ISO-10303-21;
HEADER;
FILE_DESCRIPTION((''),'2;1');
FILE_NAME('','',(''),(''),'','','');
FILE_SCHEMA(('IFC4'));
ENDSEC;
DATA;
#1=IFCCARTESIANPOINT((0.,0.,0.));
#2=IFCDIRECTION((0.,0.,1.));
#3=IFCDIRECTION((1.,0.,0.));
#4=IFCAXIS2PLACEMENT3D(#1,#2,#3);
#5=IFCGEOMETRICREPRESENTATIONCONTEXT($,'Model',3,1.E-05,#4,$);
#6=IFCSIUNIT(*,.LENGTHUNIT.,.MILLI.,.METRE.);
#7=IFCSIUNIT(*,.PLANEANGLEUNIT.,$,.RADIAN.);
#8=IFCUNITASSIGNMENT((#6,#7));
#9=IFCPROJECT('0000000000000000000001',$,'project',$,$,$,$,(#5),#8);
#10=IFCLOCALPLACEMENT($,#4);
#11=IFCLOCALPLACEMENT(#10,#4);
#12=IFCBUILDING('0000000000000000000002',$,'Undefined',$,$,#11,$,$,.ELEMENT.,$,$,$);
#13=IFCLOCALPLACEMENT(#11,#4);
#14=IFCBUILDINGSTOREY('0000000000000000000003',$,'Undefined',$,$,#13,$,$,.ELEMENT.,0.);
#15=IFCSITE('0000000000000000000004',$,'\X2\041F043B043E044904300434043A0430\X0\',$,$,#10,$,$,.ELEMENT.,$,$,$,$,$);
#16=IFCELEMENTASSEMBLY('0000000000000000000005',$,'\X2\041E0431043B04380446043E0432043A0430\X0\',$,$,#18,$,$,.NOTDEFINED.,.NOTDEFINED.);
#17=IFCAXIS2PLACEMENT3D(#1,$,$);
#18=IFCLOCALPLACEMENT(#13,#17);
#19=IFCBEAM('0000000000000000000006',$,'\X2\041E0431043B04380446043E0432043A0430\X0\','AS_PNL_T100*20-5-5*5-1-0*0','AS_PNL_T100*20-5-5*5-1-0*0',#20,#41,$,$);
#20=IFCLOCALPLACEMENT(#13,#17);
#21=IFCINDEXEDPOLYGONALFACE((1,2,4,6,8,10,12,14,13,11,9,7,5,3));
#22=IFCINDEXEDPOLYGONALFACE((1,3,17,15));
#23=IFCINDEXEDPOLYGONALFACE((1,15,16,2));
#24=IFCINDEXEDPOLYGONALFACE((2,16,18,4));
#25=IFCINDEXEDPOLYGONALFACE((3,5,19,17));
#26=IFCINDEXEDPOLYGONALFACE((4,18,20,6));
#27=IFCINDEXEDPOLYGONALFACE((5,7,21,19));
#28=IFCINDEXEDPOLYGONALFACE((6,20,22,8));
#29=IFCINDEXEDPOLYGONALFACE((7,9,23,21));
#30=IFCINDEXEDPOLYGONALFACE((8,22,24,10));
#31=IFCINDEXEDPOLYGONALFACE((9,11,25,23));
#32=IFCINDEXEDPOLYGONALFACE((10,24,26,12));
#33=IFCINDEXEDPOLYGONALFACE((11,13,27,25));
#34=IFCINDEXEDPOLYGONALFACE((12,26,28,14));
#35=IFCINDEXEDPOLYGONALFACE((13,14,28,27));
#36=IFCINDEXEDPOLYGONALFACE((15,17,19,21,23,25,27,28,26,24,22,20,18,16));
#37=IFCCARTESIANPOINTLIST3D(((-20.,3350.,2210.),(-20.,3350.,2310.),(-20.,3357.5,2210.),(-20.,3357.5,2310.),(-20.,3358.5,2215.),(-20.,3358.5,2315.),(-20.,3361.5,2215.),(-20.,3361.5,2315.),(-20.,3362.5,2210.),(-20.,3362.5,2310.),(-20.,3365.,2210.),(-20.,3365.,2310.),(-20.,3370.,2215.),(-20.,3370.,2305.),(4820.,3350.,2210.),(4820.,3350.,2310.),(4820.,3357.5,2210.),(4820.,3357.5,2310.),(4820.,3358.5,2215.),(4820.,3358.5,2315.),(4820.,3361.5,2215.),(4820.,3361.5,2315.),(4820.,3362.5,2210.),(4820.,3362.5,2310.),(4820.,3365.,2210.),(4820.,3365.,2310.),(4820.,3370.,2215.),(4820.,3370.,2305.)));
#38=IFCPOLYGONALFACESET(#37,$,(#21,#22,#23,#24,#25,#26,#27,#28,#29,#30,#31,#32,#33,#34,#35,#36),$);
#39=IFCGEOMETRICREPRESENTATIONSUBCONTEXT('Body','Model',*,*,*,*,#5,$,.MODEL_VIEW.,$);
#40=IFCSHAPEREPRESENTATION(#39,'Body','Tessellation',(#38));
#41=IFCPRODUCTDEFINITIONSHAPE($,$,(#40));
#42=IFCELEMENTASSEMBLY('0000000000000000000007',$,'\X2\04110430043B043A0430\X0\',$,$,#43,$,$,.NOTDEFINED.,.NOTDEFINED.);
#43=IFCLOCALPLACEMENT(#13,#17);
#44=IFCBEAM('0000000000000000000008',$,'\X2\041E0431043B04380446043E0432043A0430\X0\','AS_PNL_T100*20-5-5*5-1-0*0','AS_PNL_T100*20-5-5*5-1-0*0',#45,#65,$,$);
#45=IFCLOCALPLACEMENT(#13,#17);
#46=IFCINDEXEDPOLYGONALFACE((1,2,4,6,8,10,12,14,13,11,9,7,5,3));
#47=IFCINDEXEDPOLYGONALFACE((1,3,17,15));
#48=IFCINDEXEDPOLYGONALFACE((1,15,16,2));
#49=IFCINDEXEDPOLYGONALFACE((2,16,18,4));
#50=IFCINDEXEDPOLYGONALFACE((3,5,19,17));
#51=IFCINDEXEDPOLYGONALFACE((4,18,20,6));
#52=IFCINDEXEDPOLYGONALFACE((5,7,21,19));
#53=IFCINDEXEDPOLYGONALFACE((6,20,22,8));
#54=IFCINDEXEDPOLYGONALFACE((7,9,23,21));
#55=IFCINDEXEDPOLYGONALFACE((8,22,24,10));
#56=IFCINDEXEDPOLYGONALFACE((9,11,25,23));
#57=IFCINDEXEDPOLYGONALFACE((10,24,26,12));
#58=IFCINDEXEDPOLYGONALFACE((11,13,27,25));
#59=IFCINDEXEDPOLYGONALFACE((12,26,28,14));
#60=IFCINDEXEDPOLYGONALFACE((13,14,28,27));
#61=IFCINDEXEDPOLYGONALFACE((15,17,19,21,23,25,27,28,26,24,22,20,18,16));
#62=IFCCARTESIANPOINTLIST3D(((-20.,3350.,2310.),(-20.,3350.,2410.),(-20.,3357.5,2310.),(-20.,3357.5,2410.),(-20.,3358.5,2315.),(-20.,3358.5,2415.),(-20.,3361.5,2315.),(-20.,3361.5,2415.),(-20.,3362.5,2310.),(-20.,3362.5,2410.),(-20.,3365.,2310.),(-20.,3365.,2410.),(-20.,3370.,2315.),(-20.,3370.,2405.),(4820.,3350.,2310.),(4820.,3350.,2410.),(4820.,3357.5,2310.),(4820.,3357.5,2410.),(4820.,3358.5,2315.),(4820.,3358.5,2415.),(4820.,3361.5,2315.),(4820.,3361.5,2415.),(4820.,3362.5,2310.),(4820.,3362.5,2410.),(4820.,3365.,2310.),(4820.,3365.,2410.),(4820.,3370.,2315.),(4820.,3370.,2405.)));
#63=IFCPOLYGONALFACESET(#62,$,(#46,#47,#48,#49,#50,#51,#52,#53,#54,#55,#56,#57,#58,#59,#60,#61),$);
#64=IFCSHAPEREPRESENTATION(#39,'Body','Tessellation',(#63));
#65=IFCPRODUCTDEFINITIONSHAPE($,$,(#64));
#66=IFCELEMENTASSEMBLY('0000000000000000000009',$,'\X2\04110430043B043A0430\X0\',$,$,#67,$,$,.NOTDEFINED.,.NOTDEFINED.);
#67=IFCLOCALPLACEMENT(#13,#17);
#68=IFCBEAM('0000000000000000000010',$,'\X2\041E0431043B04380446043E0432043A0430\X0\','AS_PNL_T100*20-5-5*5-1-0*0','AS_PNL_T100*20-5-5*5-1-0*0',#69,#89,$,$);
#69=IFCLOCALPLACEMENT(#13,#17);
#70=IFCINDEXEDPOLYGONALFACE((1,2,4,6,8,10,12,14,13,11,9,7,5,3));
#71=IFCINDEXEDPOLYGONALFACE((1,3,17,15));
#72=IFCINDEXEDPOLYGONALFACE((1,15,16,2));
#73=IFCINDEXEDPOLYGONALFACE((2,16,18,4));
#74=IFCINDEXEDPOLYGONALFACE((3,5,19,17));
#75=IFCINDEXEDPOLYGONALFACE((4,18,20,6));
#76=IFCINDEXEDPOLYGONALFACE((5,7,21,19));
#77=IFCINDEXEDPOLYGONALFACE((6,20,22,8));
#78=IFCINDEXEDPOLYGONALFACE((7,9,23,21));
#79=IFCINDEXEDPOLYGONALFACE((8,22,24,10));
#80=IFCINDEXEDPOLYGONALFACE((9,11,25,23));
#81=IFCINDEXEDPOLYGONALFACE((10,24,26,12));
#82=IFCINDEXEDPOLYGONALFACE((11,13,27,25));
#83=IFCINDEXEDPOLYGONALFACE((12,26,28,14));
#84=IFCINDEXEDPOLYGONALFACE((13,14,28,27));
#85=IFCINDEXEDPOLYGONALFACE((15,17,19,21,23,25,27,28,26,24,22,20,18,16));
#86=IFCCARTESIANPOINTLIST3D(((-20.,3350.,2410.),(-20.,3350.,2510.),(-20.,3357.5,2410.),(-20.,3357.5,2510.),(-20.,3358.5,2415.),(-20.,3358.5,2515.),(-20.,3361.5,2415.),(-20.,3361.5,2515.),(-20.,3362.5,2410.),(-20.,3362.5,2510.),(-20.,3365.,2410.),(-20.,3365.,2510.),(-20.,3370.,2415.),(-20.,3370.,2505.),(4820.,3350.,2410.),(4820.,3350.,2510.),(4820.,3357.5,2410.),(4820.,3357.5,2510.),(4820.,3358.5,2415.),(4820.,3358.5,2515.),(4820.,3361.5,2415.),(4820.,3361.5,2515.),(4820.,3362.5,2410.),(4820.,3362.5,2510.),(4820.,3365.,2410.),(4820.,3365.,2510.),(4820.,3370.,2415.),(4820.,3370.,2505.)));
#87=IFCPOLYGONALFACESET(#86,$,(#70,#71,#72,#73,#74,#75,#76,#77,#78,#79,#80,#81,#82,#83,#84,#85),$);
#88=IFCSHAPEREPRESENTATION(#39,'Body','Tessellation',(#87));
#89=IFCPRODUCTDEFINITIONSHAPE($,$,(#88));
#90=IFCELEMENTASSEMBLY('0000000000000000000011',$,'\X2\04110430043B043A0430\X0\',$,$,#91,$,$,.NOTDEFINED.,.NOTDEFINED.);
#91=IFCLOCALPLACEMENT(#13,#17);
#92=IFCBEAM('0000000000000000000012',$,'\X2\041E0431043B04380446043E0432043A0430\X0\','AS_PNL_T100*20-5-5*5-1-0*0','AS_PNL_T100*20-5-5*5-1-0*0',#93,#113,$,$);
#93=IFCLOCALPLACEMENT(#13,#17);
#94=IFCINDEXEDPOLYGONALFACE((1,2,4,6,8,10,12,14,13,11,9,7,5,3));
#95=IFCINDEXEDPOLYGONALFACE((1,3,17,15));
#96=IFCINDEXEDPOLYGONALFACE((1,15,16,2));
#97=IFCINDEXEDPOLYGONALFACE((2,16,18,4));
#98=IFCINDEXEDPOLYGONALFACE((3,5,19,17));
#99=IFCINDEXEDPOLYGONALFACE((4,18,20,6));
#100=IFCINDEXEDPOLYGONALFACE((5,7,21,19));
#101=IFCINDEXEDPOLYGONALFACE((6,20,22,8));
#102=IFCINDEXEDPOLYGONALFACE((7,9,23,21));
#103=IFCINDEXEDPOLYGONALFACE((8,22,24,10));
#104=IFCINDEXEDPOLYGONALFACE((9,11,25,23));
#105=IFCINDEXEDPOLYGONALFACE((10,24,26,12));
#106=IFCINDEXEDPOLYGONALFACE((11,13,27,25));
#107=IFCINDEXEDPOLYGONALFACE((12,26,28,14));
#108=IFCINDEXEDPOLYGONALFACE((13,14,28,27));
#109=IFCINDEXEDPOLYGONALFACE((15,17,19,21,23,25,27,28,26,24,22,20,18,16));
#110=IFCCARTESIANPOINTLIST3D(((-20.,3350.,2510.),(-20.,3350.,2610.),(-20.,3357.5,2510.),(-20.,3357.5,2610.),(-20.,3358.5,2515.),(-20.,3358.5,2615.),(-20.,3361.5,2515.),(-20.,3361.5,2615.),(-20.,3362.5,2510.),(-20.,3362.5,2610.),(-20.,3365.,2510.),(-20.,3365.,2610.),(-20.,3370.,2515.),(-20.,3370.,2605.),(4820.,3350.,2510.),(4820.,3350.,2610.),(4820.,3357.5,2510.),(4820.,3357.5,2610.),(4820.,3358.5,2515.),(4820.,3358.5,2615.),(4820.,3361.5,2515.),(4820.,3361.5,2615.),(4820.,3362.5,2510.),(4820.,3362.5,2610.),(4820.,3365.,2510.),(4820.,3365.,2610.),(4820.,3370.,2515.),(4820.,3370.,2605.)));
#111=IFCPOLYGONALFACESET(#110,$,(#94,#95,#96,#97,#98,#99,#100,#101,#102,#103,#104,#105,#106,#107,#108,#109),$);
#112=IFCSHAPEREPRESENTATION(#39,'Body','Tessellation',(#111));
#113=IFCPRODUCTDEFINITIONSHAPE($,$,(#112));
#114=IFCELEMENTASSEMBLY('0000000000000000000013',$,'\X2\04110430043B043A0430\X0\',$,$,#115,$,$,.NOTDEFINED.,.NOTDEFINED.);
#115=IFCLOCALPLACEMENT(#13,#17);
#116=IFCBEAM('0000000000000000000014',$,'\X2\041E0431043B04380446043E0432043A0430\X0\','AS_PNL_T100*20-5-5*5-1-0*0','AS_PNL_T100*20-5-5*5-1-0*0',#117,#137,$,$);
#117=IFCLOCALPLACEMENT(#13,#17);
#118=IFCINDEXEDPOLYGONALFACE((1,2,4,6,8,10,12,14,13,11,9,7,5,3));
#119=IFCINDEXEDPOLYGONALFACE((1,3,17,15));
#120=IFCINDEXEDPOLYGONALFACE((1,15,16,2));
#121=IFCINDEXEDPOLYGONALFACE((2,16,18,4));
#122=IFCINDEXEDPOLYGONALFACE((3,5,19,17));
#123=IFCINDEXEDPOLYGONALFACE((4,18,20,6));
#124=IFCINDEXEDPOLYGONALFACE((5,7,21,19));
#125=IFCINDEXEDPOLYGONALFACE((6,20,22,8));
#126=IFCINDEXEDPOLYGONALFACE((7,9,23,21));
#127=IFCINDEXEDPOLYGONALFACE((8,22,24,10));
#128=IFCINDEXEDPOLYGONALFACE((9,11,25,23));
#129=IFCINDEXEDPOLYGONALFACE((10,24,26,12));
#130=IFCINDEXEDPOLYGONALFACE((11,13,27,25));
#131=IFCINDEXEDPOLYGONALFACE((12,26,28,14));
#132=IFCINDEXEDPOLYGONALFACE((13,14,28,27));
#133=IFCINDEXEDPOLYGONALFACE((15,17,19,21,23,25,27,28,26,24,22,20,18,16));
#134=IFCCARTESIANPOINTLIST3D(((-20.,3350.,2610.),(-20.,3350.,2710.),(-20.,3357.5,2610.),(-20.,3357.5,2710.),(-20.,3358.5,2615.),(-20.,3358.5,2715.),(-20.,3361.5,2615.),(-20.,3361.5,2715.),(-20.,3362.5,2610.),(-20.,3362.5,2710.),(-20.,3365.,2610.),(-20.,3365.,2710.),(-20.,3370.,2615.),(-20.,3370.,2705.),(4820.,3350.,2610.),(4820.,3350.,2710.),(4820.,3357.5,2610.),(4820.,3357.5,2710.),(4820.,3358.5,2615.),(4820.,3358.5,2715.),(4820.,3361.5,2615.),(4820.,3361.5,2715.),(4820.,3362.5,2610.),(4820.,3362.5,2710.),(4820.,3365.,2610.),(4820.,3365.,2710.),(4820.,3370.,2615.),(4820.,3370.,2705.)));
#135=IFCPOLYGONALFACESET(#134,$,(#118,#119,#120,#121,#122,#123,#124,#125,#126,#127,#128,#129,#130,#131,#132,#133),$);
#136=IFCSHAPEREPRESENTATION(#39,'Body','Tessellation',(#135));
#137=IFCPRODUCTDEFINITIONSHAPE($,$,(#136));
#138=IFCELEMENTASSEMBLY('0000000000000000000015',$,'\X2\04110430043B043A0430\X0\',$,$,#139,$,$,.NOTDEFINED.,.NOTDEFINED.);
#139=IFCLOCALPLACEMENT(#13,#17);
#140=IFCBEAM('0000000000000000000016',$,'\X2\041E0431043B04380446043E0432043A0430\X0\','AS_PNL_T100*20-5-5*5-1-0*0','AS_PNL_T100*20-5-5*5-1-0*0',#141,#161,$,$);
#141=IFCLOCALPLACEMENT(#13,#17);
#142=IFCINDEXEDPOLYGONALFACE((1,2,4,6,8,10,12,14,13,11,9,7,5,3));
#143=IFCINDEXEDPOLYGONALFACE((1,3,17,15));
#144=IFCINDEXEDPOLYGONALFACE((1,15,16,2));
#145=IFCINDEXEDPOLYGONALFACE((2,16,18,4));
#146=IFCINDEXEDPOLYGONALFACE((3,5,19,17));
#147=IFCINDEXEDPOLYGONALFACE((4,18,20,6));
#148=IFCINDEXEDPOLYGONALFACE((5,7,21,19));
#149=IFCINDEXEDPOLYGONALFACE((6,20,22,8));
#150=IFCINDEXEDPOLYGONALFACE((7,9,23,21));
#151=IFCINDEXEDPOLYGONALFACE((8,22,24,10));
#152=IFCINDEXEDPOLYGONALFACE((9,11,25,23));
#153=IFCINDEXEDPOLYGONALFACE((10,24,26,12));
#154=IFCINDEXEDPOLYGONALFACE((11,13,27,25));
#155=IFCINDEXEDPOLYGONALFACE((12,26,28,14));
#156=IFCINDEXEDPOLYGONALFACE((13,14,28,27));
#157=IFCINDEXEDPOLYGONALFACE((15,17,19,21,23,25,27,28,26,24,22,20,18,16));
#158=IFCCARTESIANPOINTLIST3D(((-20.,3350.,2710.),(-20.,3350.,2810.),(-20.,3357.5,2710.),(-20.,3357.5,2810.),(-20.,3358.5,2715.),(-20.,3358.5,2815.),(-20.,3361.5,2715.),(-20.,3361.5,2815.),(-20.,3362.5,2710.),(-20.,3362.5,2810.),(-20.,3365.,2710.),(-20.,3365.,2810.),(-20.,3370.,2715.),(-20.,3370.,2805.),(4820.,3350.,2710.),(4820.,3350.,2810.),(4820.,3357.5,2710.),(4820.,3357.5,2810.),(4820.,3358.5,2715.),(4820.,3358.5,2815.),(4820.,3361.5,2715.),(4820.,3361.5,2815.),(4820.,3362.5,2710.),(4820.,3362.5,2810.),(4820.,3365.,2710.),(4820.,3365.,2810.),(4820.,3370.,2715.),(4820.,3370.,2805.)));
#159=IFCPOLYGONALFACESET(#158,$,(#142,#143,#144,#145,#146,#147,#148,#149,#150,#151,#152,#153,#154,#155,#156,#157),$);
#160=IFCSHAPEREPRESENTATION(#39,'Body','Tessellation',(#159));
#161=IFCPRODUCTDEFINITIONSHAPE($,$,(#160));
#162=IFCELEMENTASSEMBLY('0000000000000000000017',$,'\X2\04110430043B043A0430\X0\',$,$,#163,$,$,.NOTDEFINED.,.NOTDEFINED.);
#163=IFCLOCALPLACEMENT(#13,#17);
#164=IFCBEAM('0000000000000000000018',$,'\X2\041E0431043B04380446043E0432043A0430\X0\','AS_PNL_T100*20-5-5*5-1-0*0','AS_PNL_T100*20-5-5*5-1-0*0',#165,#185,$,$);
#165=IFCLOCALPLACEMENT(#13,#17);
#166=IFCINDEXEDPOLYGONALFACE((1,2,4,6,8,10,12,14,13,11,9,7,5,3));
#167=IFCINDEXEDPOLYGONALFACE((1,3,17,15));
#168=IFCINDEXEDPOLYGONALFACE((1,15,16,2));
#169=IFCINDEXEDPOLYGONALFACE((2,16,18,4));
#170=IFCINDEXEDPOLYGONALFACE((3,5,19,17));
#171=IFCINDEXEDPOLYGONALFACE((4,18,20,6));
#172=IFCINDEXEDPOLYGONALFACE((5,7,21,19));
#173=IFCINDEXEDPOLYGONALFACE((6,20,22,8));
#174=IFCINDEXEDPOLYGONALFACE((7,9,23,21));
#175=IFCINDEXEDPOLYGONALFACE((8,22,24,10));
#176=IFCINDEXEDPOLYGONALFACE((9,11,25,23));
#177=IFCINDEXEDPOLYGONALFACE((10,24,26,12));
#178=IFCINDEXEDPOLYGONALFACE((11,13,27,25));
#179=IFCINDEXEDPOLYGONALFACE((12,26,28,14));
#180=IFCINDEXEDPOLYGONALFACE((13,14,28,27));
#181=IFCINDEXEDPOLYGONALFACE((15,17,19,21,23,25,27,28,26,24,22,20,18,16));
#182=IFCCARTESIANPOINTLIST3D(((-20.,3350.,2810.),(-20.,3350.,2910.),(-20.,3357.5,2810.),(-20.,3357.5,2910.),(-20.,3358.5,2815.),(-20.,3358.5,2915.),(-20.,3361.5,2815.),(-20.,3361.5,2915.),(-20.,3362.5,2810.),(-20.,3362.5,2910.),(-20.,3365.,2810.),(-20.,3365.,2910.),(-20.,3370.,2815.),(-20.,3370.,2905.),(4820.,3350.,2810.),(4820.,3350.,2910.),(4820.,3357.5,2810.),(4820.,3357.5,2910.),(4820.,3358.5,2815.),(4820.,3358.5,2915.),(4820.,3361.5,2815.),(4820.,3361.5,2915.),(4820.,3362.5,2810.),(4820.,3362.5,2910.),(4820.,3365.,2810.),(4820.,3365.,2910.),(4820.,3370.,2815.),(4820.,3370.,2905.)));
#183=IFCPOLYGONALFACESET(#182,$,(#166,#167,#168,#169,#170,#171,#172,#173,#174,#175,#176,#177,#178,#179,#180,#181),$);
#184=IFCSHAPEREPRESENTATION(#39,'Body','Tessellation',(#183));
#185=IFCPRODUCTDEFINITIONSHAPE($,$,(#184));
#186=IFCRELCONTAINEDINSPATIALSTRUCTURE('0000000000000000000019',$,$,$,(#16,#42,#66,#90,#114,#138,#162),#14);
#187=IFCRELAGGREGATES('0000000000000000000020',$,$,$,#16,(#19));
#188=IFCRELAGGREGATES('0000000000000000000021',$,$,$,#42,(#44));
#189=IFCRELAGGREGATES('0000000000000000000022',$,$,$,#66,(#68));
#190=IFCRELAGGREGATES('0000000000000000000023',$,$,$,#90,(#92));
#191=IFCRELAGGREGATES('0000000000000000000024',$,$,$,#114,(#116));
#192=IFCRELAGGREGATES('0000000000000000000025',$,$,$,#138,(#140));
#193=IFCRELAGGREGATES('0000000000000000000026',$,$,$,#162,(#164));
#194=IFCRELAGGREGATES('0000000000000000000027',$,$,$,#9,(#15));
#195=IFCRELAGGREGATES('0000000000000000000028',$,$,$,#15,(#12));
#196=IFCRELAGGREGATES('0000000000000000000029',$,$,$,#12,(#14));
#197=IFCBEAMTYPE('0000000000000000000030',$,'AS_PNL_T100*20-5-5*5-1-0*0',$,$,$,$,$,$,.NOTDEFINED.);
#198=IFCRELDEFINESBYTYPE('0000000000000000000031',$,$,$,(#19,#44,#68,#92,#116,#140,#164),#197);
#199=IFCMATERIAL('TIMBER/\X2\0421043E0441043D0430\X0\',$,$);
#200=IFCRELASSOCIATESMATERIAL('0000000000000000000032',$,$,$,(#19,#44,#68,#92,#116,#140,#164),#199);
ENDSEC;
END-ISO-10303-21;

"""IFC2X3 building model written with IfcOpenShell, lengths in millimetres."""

from ifc_helpers import new_model, si_unit, frame, origin_with_axes, place, context, subcontext, project, spatial, polyline, outline, extrude, material, type_object, element, aggregate, save


model = new_model("IFC2X3")

# Units and contexts
model_context = context("Model", 3, precision=1e-05, world=origin_with_axes())
body_context = subcontext(model_context, "Body", "Model", "MODEL_VIEW")
ifc_project = project(units=[si_unit("LENGTHUNIT", "METRE", prefix="MILLI"), si_unit("PLANEANGLEUNIT", "RADIAN")], contexts=[model_context])

# Site, building, storey
site_placement = place(None, origin_with_axes())
site = spatial("IfcSite", under=ifc_project, at=site_placement, Name="Площадка", CompositionType="ELEMENT")
building_placement = place(site_placement, origin_with_axes())
building = spatial("IfcBuilding", under=site, at=building_placement, Name="Undefined", CompositionType="ELEMENT")
storey_placement = place(building_placement, origin_with_axes())
storey = spatial("IfcBuildingStorey", under=building, at=storey_placement, Name="Undefined", CompositionType="ELEMENT", Elevation=0.0)

# Shared definitions
ifc_material = material(Name="TIMBER/Сосна")

# Element assemblies, beams
beam_type_1 = type_object("IfcBeamType", Name="AS_PNL_T100*20-5-5*5-1-0*0", PredefinedType="NOTDEFINED")
assembly_1_placement = place(storey_placement, origin_with_axes())
assembly_1 = element("IfcElementAssembly", 1, at=assembly_1_placement, inside=storey, Name="Облицовка", AssemblyPlace="NOTDEFINED", PredefinedType="NOTDEFINED")
beam_1_placement = place(assembly_1_placement, frame((4820.0, 3360.0, 2260.0), z_axis=(0.0, 0.0, 1.0), x_axis=(-1.0, 0.0, 0.0)))
beam_1 = element("IfcBeam", 2, at=beam_1_placement, type_object=beam_type_1, material=ifc_material, Name="Облицовка", Description="AS_PNL_T100*20-5-5*5-1-0*0", ObjectType="AS_PNL_T100*20-5-5*5-1-0*0", context=body_context, shape_type="SweptSolid", body=[
    extrude(outline(polyline([(-2.5, -50.0), (-10.0, -50.0), (-10.0, 50.0), (-2.5, 50.0), (-1.5, 55.0), (1.5, 55.0), (2.5, 50.0), (5.0, 50.0), (10.0, 45.0), (10.0, -45.0), (5.0, -50.0), (2.5, -50.0), (1.5, -45.0), (-1.5, -45.0), (-2.5, -50.0)])), frame((4840.0, 0.0, 0.0), z_axis=(-1.0, 0.0, 0.0), x_axis=(0.0, -1.0, 0.0)), (0.0, 0.0, 1.0), 4840.0),
])
aggregate(assembly_1, [beam_1])
assembly_2_placement = place(storey_placement, origin_with_axes())
assembly_2 = element("IfcElementAssembly", 3, at=assembly_2_placement, inside=storey, Name="Балка", AssemblyPlace="NOTDEFINED", PredefinedType="NOTDEFINED")
beam_2_placement = place(assembly_2_placement, frame((4820.0, 3360.0, 2360.0), z_axis=(0.0, 0.0, 1.0), x_axis=(-1.0, 0.0, 0.0)))
beam_2 = element("IfcBeam", 4, at=beam_2_placement, type_object=beam_type_1, material=ifc_material, Name="Облицовка", Description="AS_PNL_T100*20-5-5*5-1-0*0", ObjectType="AS_PNL_T100*20-5-5*5-1-0*0", context=body_context, shape_type="SweptSolid", body=[
    extrude(outline(polyline([(-2.5, -50.0), (-10.0, -50.0), (-10.0, 50.0), (-2.5, 50.0), (-1.5, 55.0), (1.5, 55.0), (2.5, 50.0), (5.0, 50.0), (10.0, 45.0), (10.0, -45.0), (5.0, -50.0), (2.5, -50.0), (1.5, -45.0), (-1.5, -45.0), (-2.5, -50.0)])), frame((4840.0, 0.0, 0.0), z_axis=(-1.0, 0.0, 0.0), x_axis=(0.0, -1.0, 0.0)), (0.0, 0.0, 1.0), 4840.0),
])
aggregate(assembly_2, [beam_2])
assembly_3_placement = place(storey_placement, origin_with_axes())
assembly_3 = element("IfcElementAssembly", 5, at=assembly_3_placement, inside=storey, Name="Балка", AssemblyPlace="NOTDEFINED", PredefinedType="NOTDEFINED")
beam_3_placement = place(assembly_3_placement, frame((4820.0, 3360.0, 2460.0), z_axis=(0.0, 0.0, 1.0), x_axis=(-1.0, 0.0, 0.0)))
beam_3 = element("IfcBeam", 6, at=beam_3_placement, type_object=beam_type_1, material=ifc_material, Name="Облицовка", Description="AS_PNL_T100*20-5-5*5-1-0*0", ObjectType="AS_PNL_T100*20-5-5*5-1-0*0", context=body_context, shape_type="SweptSolid", body=[
    extrude(outline(polyline([(-2.5, -50.0), (-10.0, -50.0), (-10.0, 50.0), (-2.5, 50.0), (-1.5, 55.0), (1.5, 55.0), (2.5, 50.0), (5.0, 50.0), (10.0, 45.0), (10.0, -45.0), (5.0, -50.0), (2.5, -50.0), (1.5, -45.0), (-1.5, -45.0), (-2.5, -50.0)])), frame((4840.0, 0.0, 0.0), z_axis=(-1.0, 0.0, 0.0), x_axis=(0.0, -1.0, 0.0)), (0.0, 0.0, 1.0), 4840.0),
])
aggregate(assembly_3, [beam_3])
assembly_4_placement = place(storey_placement, origin_with_axes())
assembly_4 = element("IfcElementAssembly", 7, at=assembly_4_placement, inside=storey, Name="Балка", AssemblyPlace="NOTDEFINED", PredefinedType="NOTDEFINED")
beam_4_placement = place(assembly_4_placement, frame((4820.0, 3360.0, 2560.0), z_axis=(0.0, 0.0, 1.0), x_axis=(-1.0, 0.0, 0.0)))
beam_4 = element("IfcBeam", 8, at=beam_4_placement, type_object=beam_type_1, material=ifc_material, Name="Облицовка", Description="AS_PNL_T100*20-5-5*5-1-0*0", ObjectType="AS_PNL_T100*20-5-5*5-1-0*0", context=body_context, shape_type="SweptSolid", body=[
    extrude(outline(polyline([(-2.5, -50.0), (-10.0, -50.0), (-10.0, 50.0), (-2.5, 50.0), (-1.5, 55.0), (1.5, 55.0), (2.5, 50.0), (5.0, 50.0), (10.0, 45.0), (10.0, -45.0), (5.0, -50.0), (2.5, -50.0), (1.5, -45.0), (-1.5, -45.0), (-2.5, -50.0)])), frame((4840.0, 0.0, 0.0), z_axis=(-1.0, 0.0, 0.0), x_axis=(0.0, -1.0, 0.0)), (0.0, 0.0, 1.0), 4840.0),
])
aggregate(assembly_4, [beam_4])
assembly_5_placement = place(storey_placement, origin_with_axes())
assembly_5 = element("IfcElementAssembly", 9, at=assembly_5_placement, inside=storey, Name="Балка", AssemblyPlace="NOTDEFINED", PredefinedType="NOTDEFINED")
beam_5_placement = place(assembly_5_placement, frame((4820.0, 3360.0, 2660.0), z_axis=(0.0, 0.0, 1.0), x_axis=(-1.0, 0.0, 0.0)))
beam_5 = element("IfcBeam", 10, at=beam_5_placement, type_object=beam_type_1, material=ifc_material, Name="Облицовка", Description="AS_PNL_T100*20-5-5*5-1-0*0", ObjectType="AS_PNL_T100*20-5-5*5-1-0*0", context=body_context, shape_type="SweptSolid", body=[
    extrude(outline(polyline([(-2.5, -50.0), (-10.0, -50.0), (-10.0, 50.0), (-2.5, 50.0), (-1.5, 55.0), (1.5, 55.0), (2.5, 50.0), (5.0, 50.0), (10.0, 45.0), (10.0, -45.0), (5.0, -50.0), (2.5, -50.0), (1.5, -45.0), (-1.5, -45.0), (-2.5, -50.0)])), frame((4840.0, 0.0, 0.0), z_axis=(-1.0, 0.0, 0.0), x_axis=(0.0, -1.0, 0.0)), (0.0, 0.0, 1.0), 4840.0),
])
aggregate(assembly_5, [beam_5])
assembly_6_placement = place(storey_placement, origin_with_axes())
assembly_6 = element("IfcElementAssembly", 11, at=assembly_6_placement, inside=storey, Name="Балка", AssemblyPlace="NOTDEFINED", PredefinedType="NOTDEFINED")
beam_6_placement = place(assembly_6_placement, frame((4820.0, 3360.0, 2760.0), z_axis=(0.0, 0.0, 1.0), x_axis=(-1.0, 0.0, 0.0)))
beam_6 = element("IfcBeam", 12, at=beam_6_placement, type_object=beam_type_1, material=ifc_material, Name="Облицовка", Description="AS_PNL_T100*20-5-5*5-1-0*0", ObjectType="AS_PNL_T100*20-5-5*5-1-0*0", context=body_context, shape_type="SweptSolid", body=[
    extrude(outline(polyline([(-2.5, -50.0), (-10.0, -50.0), (-10.0, 50.0), (-2.5, 50.0), (-1.5, 55.0), (1.5, 55.0), (2.5, 50.0), (5.0, 50.0), (10.0, 45.0), (10.0, -45.0), (5.0, -50.0), (2.5, -50.0), (1.5, -45.0), (-1.5, -45.0), (-2.5, -50.0)])), frame((4840.0, 0.0, 0.0), z_axis=(-1.0, 0.0, 0.0), x_axis=(0.0, -1.0, 0.0)), (0.0, 0.0, 1.0), 4840.0),
])
aggregate(assembly_6, [beam_6])
assembly_7_placement = place(storey_placement, origin_with_axes())
assembly_7 = element("IfcElementAssembly", 13, at=assembly_7_placement, inside=storey, Name="Балка", AssemblyPlace="NOTDEFINED", PredefinedType="NOTDEFINED")
beam_7_placement = place(assembly_7_placement, frame((4820.0, 3360.0, 2860.0), z_axis=(0.0, 0.0, 1.0), x_axis=(-1.0, 0.0, 0.0)))
beam_7 = element("IfcBeam", 14, at=beam_7_placement, type_object=beam_type_1, material=ifc_material, Name="Облицовка", Description="AS_PNL_T100*20-5-5*5-1-0*0", ObjectType="AS_PNL_T100*20-5-5*5-1-0*0", context=body_context, shape_type="SweptSolid", body=[
    extrude(outline(polyline([(-2.5, -50.0), (-10.0, -50.0), (-10.0, 50.0), (-2.5, 50.0), (-1.5, 55.0), (1.5, 55.0), (2.5, 50.0), (5.0, 50.0), (10.0, 45.0), (10.0, -45.0), (5.0, -50.0), (2.5, -50.0), (1.5, -45.0), (-1.5, -45.0), (-2.5, -50.0)])), frame((4840.0, 0.0, 0.0), z_axis=(-1.0, 0.0, 0.0), x_axis=(0.0, -1.0, 0.0)), (0.0, 0.0, 1.0), 4840.0),
])
aggregate(assembly_7, [beam_7])

save(model, "model.ifc")
